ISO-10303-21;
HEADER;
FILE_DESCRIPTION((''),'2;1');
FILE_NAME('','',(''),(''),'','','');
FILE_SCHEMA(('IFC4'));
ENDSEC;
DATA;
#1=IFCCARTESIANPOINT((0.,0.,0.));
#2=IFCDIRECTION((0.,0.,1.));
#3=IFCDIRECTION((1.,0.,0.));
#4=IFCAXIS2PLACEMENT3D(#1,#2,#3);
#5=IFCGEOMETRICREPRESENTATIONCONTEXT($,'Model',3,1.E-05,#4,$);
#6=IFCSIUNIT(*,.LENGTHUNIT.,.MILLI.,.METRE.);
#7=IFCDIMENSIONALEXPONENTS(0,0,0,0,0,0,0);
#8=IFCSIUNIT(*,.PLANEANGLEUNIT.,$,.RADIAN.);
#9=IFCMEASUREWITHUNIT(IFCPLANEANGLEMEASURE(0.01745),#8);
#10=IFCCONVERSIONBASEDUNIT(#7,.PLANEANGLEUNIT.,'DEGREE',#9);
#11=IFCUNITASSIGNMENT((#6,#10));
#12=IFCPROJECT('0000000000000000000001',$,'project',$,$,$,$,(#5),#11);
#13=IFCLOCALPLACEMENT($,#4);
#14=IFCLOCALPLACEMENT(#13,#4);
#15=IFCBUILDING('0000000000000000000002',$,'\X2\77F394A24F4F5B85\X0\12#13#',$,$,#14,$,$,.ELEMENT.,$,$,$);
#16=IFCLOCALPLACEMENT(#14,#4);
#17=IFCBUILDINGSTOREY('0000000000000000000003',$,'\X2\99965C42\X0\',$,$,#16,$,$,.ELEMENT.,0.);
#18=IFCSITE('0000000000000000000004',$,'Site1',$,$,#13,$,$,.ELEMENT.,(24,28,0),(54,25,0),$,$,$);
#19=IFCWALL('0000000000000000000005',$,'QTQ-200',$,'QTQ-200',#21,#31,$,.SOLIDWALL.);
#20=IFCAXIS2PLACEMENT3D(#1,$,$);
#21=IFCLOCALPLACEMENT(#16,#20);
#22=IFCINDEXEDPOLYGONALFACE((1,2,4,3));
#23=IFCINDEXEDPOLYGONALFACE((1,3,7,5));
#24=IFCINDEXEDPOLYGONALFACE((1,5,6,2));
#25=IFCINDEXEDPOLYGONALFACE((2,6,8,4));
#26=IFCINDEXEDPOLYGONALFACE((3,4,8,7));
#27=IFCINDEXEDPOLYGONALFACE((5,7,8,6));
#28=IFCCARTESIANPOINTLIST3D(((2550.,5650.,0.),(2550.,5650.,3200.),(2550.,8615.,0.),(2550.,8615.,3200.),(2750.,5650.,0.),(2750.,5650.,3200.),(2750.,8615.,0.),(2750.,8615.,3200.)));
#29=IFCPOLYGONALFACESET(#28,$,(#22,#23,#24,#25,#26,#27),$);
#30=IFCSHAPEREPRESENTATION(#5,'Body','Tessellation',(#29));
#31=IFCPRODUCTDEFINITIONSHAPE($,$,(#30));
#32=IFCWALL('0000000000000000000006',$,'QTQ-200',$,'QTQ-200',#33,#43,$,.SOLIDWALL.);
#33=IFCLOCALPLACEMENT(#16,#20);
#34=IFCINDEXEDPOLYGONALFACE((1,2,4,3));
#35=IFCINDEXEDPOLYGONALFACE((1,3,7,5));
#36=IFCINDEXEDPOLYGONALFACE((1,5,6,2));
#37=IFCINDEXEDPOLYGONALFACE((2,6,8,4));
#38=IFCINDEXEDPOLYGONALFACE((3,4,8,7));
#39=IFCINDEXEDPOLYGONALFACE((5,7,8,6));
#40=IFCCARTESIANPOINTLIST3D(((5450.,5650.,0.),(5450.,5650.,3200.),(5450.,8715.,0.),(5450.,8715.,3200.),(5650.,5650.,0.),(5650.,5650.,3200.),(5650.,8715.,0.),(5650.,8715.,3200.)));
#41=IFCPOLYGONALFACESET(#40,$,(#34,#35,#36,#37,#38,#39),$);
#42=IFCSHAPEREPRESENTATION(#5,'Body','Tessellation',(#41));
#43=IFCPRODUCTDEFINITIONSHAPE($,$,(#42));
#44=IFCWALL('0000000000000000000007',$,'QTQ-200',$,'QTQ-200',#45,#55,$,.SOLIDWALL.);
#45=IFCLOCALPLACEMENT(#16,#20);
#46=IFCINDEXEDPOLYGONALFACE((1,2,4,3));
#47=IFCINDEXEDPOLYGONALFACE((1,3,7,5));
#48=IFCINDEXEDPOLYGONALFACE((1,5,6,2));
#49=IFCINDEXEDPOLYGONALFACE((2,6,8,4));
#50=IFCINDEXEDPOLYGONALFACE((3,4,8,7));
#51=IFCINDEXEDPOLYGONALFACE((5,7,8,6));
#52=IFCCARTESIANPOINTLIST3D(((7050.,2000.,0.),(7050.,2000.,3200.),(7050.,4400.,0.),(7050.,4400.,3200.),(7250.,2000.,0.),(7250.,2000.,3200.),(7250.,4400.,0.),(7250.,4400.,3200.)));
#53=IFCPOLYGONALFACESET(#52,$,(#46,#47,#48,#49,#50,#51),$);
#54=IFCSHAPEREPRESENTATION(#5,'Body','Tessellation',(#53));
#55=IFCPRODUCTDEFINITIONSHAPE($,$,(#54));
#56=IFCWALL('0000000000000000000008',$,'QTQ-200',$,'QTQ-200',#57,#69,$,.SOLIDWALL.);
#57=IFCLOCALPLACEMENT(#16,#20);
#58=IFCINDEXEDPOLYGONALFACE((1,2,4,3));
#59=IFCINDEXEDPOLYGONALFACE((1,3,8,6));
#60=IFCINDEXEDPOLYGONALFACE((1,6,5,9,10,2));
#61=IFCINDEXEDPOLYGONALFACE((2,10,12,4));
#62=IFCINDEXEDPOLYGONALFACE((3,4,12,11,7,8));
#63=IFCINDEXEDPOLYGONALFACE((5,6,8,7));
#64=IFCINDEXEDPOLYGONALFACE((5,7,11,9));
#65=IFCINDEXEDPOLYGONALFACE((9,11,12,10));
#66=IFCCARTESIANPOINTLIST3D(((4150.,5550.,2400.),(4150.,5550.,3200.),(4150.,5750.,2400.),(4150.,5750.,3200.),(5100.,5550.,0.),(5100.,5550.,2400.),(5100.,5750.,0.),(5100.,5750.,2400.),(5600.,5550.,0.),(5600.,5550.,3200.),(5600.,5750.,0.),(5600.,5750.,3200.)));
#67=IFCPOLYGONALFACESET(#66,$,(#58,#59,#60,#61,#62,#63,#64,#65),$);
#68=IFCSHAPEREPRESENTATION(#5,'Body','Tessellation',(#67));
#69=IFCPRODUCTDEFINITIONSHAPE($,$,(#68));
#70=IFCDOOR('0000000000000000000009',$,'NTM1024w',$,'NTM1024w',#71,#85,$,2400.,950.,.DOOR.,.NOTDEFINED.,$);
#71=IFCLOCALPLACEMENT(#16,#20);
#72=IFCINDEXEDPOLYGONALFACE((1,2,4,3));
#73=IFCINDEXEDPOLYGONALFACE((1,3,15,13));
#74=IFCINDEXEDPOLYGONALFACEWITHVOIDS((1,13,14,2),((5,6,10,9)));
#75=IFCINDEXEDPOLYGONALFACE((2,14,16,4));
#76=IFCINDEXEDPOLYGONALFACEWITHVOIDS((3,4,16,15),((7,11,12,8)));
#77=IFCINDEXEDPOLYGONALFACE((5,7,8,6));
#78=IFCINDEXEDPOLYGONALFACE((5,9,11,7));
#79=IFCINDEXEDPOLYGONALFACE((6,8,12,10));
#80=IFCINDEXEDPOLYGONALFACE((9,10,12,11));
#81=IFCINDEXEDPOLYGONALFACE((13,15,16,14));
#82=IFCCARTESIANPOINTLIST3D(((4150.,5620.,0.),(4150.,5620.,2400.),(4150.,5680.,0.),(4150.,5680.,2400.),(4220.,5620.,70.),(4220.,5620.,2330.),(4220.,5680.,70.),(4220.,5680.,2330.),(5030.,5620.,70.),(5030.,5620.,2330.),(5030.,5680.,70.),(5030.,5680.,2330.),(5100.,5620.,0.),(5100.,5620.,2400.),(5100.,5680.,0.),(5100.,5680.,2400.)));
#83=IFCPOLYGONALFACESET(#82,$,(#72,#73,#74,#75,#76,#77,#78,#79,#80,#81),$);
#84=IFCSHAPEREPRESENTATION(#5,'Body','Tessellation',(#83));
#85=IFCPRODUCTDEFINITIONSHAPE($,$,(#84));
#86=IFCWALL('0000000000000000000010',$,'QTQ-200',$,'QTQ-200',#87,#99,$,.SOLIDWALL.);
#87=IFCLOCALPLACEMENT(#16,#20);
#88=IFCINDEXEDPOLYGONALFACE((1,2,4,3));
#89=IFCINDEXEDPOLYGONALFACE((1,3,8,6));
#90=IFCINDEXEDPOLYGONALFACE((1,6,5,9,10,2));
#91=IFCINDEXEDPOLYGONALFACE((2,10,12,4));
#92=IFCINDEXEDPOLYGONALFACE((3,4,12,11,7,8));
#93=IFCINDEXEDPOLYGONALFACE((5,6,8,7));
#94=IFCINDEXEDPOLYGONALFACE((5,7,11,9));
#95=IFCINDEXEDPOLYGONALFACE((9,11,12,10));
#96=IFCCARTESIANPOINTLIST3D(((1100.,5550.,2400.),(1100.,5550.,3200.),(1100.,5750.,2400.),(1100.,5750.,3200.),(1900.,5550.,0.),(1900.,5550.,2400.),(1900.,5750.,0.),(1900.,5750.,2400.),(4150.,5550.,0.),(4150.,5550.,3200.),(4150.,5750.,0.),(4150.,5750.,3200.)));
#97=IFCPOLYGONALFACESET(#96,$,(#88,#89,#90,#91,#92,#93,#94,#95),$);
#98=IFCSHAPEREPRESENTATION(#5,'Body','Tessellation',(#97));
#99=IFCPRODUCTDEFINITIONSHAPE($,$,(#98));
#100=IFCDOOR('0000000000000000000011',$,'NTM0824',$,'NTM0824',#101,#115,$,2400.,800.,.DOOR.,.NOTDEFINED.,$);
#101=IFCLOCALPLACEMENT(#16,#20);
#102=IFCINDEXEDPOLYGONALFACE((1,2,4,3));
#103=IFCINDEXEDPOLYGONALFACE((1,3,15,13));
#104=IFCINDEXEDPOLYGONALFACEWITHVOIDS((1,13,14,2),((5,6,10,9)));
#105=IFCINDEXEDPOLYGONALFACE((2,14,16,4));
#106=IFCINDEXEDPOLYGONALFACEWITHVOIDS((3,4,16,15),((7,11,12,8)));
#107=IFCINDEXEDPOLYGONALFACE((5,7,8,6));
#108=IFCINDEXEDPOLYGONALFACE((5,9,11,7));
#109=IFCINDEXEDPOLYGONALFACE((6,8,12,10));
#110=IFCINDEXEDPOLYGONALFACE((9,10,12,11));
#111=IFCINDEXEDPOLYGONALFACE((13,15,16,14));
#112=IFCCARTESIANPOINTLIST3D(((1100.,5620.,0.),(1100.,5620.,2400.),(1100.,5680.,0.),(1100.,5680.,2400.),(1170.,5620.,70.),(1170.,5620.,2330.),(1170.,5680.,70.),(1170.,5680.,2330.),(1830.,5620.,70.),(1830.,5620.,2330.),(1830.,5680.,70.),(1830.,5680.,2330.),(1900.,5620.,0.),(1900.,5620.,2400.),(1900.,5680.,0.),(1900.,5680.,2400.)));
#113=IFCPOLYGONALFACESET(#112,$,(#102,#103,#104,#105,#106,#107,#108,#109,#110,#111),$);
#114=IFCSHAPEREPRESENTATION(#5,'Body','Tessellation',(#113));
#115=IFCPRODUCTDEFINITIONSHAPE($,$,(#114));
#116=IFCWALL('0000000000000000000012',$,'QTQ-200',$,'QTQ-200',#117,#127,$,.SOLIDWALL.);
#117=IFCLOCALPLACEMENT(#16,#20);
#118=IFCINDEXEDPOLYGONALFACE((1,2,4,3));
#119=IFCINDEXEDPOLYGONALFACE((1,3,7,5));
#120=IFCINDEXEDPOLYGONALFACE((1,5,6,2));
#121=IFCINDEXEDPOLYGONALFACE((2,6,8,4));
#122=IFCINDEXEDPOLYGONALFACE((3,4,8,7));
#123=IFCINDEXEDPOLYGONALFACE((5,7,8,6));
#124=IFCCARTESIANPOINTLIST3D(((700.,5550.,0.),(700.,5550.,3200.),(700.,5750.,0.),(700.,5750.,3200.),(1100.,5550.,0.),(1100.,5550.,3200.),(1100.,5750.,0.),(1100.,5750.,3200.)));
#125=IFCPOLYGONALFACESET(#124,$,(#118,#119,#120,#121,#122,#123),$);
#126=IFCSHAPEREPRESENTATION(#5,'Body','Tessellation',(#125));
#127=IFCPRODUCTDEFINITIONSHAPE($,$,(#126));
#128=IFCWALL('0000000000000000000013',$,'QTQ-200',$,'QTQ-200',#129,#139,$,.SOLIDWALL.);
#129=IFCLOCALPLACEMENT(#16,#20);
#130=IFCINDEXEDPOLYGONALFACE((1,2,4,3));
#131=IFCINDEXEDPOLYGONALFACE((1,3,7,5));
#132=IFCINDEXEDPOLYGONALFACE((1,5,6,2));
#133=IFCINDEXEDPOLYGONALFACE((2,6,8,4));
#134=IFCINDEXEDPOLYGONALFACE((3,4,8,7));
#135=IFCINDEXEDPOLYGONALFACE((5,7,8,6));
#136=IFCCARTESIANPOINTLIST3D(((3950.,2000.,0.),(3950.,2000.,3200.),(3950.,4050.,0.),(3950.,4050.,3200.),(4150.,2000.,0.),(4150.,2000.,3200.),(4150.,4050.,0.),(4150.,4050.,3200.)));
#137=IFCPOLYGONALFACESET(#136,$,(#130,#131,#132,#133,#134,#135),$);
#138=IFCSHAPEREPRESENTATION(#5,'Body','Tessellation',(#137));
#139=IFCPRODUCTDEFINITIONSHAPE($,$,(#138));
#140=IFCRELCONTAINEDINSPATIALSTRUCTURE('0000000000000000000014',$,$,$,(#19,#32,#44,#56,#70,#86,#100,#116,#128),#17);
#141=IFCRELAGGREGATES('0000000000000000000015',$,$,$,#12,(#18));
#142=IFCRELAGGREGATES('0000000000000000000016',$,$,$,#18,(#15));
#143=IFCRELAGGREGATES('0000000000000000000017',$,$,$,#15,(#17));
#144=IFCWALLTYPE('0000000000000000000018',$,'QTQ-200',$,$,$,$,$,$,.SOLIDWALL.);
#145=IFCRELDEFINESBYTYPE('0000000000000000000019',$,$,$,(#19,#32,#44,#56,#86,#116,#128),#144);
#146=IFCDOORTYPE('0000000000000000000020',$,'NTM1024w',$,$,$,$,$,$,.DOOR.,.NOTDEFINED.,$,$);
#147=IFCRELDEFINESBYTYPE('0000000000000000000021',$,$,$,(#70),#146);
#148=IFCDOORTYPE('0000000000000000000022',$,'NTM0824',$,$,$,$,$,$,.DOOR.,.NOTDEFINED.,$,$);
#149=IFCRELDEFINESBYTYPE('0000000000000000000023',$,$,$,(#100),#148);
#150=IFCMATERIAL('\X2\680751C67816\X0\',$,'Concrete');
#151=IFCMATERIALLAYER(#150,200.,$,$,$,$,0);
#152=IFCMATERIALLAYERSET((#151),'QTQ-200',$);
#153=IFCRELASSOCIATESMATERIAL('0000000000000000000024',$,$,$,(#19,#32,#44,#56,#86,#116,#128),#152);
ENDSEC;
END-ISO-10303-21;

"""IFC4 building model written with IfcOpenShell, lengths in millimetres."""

from ifc_helpers import new_model, entity, si_unit, converted_unit, frame, origin_with_axes, place, context, project, spatial, polyline, outline, extrude, material, layer, layer_set, type_object, element, fill, save


model = new_model("IFC4")

# Units and contexts
model_context = context("Model", 3, precision=1e-05, world=origin_with_axes())
ifc_project = project(units=[si_unit("LENGTHUNIT", "METRE", prefix="MILLI"), converted_unit("PLANEANGLEUNIT", "DEGREE", entity("IfcPlaneAngleMeasure", 0.01745), si_unit("PLANEANGLEUNIT", "RADIAN"), dimensions=[0, 0, 0, 0, 0, 0, 0])], contexts=[model_context])

# Site, building, storey
site_placement = place(None, origin_with_axes())
site = spatial("IfcSite", under=ifc_project, at=site_placement, Name="Site1", CompositionType="ELEMENT", RefLatitude=(24, 28, 0), RefLongitude=(54, 25, 0))
building_placement = place(site_placement, origin_with_axes())
building = spatial("IfcBuilding", under=site, at=building_placement, Name="石钢住宅12#13#", CompositionType="ELEMENT")
storey_placement = place(building_placement, origin_with_axes())
storey = spatial("IfcBuildingStorey", under=building, at=storey_placement, Name="首层", CompositionType="ELEMENT", Elevation=0.0)

# Shared definitions
ifc_material = material(Name="标准砖", Category="Concrete")
ifc_layer = layer(ifc_material, 200.0, Priority=0)
ifc_layer_set = layer_set([ifc_layer], Name="QTQ-200")
wall_type = type_object("IfcWallType", Name="QTQ-200", PredefinedType="SOLIDWALL")

# Walls
wall_1_placement = place(storey_placement, origin_with_axes())
element("IfcWall", 1, at=wall_1_placement, inside=storey, type_object=wall_type, material=ifc_layer_set, Name="QTQ-200", ObjectType="QTQ-200", PredefinedType="SOLIDWALL", context=model_context, shape_type="SweptSolid", body=[
    extrude(outline(polyline([(0.0, 0.0), (3200.0, 0.0), (3200.0, 2965.0), (0.0, 2965.0), (0.0, 0.0)])), frame((2750.0, 8615.0, 3200.0), z_axis=(-1.0, 0.0, 0.0), x_axis=(0.0, 0.0, -1.0)), (0.0, 0.0, 1.0), 200.0),
])
wall_2_placement = place(storey_placement, origin_with_axes())
element("IfcWall", 2, at=wall_2_placement, inside=storey, type_object=wall_type, material=ifc_layer_set, Name="QTQ-200", ObjectType="QTQ-200", PredefinedType="SOLIDWALL", context=model_context, shape_type="SweptSolid", body=[
    extrude(outline(polyline([(0.0, 0.0), (3200.0, 0.0), (3200.0, 3065.0), (0.0, 3065.0), (0.0, 0.0)])), frame((5450.0, 5650.0, 3200.0), z_axis=(1.0, 0.0, 0.0), x_axis=(0.0, 0.0, -1.0)), (0.0, 0.0, 1.0), 200.0),
])
wall_3_placement = place(storey_placement, origin_with_axes())
element("IfcWall", 3, at=wall_3_placement, inside=storey, type_object=wall_type, material=ifc_layer_set, Name="QTQ-200", ObjectType="QTQ-200", PredefinedType="SOLIDWALL", context=model_context, shape_type="SweptSolid", body=[
    extrude(outline(polyline([(0.0, 0.0), (3200.0, 0.0), (3200.0, 2400.0), (0.0, 2400.0), (0.0, 0.0)])), frame((7050.0, 2000.0, 3200.0), z_axis=(1.0, 0.0, 0.0), x_axis=(0.0, 0.0, -1.0)), (0.0, 0.0, 1.0), 200.0),
])

# Walls, openings, doors
wall_4_placement = place(storey_placement, origin_with_axes())
wall_4 = element("IfcWall", 4, at=wall_4_placement, inside=storey, type_object=wall_type, material=ifc_layer_set, Name="QTQ-200", ObjectType="QTQ-200", PredefinedType="SOLIDWALL", context=model_context, shape_type="SweptSolid", body=[
    extrude(outline(polyline([(0.0, 0.0), (3200.0, 0.0), (3200.0, 1450.0), (0.0, 1450.0), (0.0, 0.0)])), frame((4150.0, 5750.0, 3200.0), z_axis=(0.0, -1.0, 0.0), x_axis=(0.0, 0.0, -1.0)), (0.0, 0.0, 1.0), 200.0),
])
opening_1_placement = place(storey_placement, origin_with_axes())
opening_1 = element("IfcOpeningElement", 5, at=opening_1_placement, cuts=wall_4, PredefinedType="OPENING", context=model_context, shape_type="SweptSolid", body=[
    extrude(outline(polyline([(0.0, 0.0), (950.0, 0.0), (950.0, 2400.0), (0.0, 2400.0), (0.0, 0.0)])), frame((4150.0, 6750.0, 0.0), z_axis=(0.0, -1.0, 0.0), x_axis=(1.0, 0.0, 0.0)), (0.0, 0.0, 1.0), 2200.0),
])
door_type_1 = type_object("IfcDoorType", Name="NTM1024w", OperationType="NOTDEFINED", PredefinedType="DOOR")
door_1_placement = place(storey_placement, origin_with_axes())
door_1 = element("IfcDoor", 6, at=door_1_placement, inside=storey, type_object=door_type_1, Name="NTM1024w", ObjectType="NTM1024w", OperationType="NOTDEFINED", OverallHeight=2400.0, OverallWidth=950.0, PredefinedType="DOOR", context=model_context, shape_type="SweptSolid", body=[
    extrude(outline(polyline([(-475.0, -1200.0), (475.0, -1200.0), (475.0, 1200.0), (-475.0, 1200.0), (-475.0, -1200.0)]), holes=[polyline([(-405.0, -1130.0), (-405.0, 1130.0), (405.0, 1130.0), (405.0, -1130.0), (-405.0, -1130.0)])]), frame((4625.0, 5680.0, 1200.0), z_axis=(0.0, -1.0, 0.0), x_axis=(1.0, 0.0, 0.0)), (0.0, 0.0, 1.0), 60.0),
])
fill(opening_1, door_1)
wall_5_placement = place(storey_placement, origin_with_axes())
wall_5 = element("IfcWall", 7, at=wall_5_placement, inside=storey, type_object=wall_type, material=ifc_layer_set, Name="QTQ-200", ObjectType="QTQ-200", PredefinedType="SOLIDWALL", context=model_context, shape_type="SweptSolid", body=[
    extrude(outline(polyline([(0.0, 0.0), (3200.0, 0.0), (3200.0, 3050.0), (0.0, 3050.0), (0.0, 0.0)])), frame((1100.0, 5750.0, 3200.0), z_axis=(0.0, -1.0, 0.0), x_axis=(0.0, 0.0, -1.0)), (0.0, 0.0, 1.0), 200.0),
])
opening_2_placement = place(storey_placement, origin_with_axes())
opening_2 = element("IfcOpeningElement", 8, at=opening_2_placement, cuts=wall_5, PredefinedType="OPENING", context=model_context, shape_type="SweptSolid", body=[
    extrude(outline(polyline([(0.0, 0.0), (800.0, 0.0), (800.0, 2400.0), (0.0, 2400.0), (0.0, 0.0)])), frame((1100.0, 6750.0, 0.0), z_axis=(0.0, -1.0, 0.0), x_axis=(1.0, 0.0, 0.0)), (0.0, 0.0, 1.0), 2200.0),
])
door_type_2 = type_object("IfcDoorType", Name="NTM0824", OperationType="NOTDEFINED", PredefinedType="DOOR")
door_2_placement = place(storey_placement, origin_with_axes())
door_2 = element("IfcDoor", 9, at=door_2_placement, inside=storey, type_object=door_type_2, Name="NTM0824", ObjectType="NTM0824", OperationType="NOTDEFINED", OverallHeight=2400.0, OverallWidth=800.0, PredefinedType="DOOR", context=model_context, shape_type="SweptSolid", body=[
    extrude(outline(polyline([(-400.0, -1200.0), (400.0, -1200.0), (400.0, 1200.0), (-400.0, 1200.0), (-400.0, -1200.0)]), holes=[polyline([(-330.0, -1130.0), (-330.0, 1130.0), (330.0, 1130.0), (330.0, -1130.0), (-330.0, -1130.0)])]), frame((1500.0, 5680.0, 1200.0), z_axis=(0.0, -1.0, 0.0), x_axis=(1.0, 0.0, 0.0)), (0.0, 0.0, 1.0), 60.0),
])
fill(opening_2, door_2)

# Walls
wall_6_placement = place(storey_placement, origin_with_axes())
element("IfcWall", 10, at=wall_6_placement, inside=storey, type_object=wall_type, material=ifc_layer_set, Name="QTQ-200", ObjectType="QTQ-200", PredefinedType="SOLIDWALL", context=model_context, shape_type="SweptSolid", body=[
    extrude(outline(polyline([(0.0, 0.0), (3200.0, 0.0), (3200.0, 400.0), (0.0, 400.0), (0.0, 0.0)])), frame((700.0, 5750.0, 3200.0), z_axis=(0.0, -1.0, 0.0), x_axis=(0.0, 0.0, -1.0)), (0.0, 0.0, 1.0), 200.0),
])
wall_7_placement = place(storey_placement, origin_with_axes())
element("IfcWall", 11, at=wall_7_placement, inside=storey, type_object=wall_type, material=ifc_layer_set, Name="QTQ-200", ObjectType="QTQ-200", PredefinedType="SOLIDWALL", context=model_context, shape_type="SweptSolid", body=[
    extrude(outline(polyline([(0.0, 0.0), (3200.0, 0.0), (3200.0, 2050.0), (0.0, 2050.0), (0.0, 0.0)])), frame((3950.0, 2000.0, 3200.0), z_axis=(1.0, 0.0, 0.0), x_axis=(0.0, 0.0, -1.0)), (0.0, 0.0, 1.0), 200.0),
])

save(model, "model.ifc")
